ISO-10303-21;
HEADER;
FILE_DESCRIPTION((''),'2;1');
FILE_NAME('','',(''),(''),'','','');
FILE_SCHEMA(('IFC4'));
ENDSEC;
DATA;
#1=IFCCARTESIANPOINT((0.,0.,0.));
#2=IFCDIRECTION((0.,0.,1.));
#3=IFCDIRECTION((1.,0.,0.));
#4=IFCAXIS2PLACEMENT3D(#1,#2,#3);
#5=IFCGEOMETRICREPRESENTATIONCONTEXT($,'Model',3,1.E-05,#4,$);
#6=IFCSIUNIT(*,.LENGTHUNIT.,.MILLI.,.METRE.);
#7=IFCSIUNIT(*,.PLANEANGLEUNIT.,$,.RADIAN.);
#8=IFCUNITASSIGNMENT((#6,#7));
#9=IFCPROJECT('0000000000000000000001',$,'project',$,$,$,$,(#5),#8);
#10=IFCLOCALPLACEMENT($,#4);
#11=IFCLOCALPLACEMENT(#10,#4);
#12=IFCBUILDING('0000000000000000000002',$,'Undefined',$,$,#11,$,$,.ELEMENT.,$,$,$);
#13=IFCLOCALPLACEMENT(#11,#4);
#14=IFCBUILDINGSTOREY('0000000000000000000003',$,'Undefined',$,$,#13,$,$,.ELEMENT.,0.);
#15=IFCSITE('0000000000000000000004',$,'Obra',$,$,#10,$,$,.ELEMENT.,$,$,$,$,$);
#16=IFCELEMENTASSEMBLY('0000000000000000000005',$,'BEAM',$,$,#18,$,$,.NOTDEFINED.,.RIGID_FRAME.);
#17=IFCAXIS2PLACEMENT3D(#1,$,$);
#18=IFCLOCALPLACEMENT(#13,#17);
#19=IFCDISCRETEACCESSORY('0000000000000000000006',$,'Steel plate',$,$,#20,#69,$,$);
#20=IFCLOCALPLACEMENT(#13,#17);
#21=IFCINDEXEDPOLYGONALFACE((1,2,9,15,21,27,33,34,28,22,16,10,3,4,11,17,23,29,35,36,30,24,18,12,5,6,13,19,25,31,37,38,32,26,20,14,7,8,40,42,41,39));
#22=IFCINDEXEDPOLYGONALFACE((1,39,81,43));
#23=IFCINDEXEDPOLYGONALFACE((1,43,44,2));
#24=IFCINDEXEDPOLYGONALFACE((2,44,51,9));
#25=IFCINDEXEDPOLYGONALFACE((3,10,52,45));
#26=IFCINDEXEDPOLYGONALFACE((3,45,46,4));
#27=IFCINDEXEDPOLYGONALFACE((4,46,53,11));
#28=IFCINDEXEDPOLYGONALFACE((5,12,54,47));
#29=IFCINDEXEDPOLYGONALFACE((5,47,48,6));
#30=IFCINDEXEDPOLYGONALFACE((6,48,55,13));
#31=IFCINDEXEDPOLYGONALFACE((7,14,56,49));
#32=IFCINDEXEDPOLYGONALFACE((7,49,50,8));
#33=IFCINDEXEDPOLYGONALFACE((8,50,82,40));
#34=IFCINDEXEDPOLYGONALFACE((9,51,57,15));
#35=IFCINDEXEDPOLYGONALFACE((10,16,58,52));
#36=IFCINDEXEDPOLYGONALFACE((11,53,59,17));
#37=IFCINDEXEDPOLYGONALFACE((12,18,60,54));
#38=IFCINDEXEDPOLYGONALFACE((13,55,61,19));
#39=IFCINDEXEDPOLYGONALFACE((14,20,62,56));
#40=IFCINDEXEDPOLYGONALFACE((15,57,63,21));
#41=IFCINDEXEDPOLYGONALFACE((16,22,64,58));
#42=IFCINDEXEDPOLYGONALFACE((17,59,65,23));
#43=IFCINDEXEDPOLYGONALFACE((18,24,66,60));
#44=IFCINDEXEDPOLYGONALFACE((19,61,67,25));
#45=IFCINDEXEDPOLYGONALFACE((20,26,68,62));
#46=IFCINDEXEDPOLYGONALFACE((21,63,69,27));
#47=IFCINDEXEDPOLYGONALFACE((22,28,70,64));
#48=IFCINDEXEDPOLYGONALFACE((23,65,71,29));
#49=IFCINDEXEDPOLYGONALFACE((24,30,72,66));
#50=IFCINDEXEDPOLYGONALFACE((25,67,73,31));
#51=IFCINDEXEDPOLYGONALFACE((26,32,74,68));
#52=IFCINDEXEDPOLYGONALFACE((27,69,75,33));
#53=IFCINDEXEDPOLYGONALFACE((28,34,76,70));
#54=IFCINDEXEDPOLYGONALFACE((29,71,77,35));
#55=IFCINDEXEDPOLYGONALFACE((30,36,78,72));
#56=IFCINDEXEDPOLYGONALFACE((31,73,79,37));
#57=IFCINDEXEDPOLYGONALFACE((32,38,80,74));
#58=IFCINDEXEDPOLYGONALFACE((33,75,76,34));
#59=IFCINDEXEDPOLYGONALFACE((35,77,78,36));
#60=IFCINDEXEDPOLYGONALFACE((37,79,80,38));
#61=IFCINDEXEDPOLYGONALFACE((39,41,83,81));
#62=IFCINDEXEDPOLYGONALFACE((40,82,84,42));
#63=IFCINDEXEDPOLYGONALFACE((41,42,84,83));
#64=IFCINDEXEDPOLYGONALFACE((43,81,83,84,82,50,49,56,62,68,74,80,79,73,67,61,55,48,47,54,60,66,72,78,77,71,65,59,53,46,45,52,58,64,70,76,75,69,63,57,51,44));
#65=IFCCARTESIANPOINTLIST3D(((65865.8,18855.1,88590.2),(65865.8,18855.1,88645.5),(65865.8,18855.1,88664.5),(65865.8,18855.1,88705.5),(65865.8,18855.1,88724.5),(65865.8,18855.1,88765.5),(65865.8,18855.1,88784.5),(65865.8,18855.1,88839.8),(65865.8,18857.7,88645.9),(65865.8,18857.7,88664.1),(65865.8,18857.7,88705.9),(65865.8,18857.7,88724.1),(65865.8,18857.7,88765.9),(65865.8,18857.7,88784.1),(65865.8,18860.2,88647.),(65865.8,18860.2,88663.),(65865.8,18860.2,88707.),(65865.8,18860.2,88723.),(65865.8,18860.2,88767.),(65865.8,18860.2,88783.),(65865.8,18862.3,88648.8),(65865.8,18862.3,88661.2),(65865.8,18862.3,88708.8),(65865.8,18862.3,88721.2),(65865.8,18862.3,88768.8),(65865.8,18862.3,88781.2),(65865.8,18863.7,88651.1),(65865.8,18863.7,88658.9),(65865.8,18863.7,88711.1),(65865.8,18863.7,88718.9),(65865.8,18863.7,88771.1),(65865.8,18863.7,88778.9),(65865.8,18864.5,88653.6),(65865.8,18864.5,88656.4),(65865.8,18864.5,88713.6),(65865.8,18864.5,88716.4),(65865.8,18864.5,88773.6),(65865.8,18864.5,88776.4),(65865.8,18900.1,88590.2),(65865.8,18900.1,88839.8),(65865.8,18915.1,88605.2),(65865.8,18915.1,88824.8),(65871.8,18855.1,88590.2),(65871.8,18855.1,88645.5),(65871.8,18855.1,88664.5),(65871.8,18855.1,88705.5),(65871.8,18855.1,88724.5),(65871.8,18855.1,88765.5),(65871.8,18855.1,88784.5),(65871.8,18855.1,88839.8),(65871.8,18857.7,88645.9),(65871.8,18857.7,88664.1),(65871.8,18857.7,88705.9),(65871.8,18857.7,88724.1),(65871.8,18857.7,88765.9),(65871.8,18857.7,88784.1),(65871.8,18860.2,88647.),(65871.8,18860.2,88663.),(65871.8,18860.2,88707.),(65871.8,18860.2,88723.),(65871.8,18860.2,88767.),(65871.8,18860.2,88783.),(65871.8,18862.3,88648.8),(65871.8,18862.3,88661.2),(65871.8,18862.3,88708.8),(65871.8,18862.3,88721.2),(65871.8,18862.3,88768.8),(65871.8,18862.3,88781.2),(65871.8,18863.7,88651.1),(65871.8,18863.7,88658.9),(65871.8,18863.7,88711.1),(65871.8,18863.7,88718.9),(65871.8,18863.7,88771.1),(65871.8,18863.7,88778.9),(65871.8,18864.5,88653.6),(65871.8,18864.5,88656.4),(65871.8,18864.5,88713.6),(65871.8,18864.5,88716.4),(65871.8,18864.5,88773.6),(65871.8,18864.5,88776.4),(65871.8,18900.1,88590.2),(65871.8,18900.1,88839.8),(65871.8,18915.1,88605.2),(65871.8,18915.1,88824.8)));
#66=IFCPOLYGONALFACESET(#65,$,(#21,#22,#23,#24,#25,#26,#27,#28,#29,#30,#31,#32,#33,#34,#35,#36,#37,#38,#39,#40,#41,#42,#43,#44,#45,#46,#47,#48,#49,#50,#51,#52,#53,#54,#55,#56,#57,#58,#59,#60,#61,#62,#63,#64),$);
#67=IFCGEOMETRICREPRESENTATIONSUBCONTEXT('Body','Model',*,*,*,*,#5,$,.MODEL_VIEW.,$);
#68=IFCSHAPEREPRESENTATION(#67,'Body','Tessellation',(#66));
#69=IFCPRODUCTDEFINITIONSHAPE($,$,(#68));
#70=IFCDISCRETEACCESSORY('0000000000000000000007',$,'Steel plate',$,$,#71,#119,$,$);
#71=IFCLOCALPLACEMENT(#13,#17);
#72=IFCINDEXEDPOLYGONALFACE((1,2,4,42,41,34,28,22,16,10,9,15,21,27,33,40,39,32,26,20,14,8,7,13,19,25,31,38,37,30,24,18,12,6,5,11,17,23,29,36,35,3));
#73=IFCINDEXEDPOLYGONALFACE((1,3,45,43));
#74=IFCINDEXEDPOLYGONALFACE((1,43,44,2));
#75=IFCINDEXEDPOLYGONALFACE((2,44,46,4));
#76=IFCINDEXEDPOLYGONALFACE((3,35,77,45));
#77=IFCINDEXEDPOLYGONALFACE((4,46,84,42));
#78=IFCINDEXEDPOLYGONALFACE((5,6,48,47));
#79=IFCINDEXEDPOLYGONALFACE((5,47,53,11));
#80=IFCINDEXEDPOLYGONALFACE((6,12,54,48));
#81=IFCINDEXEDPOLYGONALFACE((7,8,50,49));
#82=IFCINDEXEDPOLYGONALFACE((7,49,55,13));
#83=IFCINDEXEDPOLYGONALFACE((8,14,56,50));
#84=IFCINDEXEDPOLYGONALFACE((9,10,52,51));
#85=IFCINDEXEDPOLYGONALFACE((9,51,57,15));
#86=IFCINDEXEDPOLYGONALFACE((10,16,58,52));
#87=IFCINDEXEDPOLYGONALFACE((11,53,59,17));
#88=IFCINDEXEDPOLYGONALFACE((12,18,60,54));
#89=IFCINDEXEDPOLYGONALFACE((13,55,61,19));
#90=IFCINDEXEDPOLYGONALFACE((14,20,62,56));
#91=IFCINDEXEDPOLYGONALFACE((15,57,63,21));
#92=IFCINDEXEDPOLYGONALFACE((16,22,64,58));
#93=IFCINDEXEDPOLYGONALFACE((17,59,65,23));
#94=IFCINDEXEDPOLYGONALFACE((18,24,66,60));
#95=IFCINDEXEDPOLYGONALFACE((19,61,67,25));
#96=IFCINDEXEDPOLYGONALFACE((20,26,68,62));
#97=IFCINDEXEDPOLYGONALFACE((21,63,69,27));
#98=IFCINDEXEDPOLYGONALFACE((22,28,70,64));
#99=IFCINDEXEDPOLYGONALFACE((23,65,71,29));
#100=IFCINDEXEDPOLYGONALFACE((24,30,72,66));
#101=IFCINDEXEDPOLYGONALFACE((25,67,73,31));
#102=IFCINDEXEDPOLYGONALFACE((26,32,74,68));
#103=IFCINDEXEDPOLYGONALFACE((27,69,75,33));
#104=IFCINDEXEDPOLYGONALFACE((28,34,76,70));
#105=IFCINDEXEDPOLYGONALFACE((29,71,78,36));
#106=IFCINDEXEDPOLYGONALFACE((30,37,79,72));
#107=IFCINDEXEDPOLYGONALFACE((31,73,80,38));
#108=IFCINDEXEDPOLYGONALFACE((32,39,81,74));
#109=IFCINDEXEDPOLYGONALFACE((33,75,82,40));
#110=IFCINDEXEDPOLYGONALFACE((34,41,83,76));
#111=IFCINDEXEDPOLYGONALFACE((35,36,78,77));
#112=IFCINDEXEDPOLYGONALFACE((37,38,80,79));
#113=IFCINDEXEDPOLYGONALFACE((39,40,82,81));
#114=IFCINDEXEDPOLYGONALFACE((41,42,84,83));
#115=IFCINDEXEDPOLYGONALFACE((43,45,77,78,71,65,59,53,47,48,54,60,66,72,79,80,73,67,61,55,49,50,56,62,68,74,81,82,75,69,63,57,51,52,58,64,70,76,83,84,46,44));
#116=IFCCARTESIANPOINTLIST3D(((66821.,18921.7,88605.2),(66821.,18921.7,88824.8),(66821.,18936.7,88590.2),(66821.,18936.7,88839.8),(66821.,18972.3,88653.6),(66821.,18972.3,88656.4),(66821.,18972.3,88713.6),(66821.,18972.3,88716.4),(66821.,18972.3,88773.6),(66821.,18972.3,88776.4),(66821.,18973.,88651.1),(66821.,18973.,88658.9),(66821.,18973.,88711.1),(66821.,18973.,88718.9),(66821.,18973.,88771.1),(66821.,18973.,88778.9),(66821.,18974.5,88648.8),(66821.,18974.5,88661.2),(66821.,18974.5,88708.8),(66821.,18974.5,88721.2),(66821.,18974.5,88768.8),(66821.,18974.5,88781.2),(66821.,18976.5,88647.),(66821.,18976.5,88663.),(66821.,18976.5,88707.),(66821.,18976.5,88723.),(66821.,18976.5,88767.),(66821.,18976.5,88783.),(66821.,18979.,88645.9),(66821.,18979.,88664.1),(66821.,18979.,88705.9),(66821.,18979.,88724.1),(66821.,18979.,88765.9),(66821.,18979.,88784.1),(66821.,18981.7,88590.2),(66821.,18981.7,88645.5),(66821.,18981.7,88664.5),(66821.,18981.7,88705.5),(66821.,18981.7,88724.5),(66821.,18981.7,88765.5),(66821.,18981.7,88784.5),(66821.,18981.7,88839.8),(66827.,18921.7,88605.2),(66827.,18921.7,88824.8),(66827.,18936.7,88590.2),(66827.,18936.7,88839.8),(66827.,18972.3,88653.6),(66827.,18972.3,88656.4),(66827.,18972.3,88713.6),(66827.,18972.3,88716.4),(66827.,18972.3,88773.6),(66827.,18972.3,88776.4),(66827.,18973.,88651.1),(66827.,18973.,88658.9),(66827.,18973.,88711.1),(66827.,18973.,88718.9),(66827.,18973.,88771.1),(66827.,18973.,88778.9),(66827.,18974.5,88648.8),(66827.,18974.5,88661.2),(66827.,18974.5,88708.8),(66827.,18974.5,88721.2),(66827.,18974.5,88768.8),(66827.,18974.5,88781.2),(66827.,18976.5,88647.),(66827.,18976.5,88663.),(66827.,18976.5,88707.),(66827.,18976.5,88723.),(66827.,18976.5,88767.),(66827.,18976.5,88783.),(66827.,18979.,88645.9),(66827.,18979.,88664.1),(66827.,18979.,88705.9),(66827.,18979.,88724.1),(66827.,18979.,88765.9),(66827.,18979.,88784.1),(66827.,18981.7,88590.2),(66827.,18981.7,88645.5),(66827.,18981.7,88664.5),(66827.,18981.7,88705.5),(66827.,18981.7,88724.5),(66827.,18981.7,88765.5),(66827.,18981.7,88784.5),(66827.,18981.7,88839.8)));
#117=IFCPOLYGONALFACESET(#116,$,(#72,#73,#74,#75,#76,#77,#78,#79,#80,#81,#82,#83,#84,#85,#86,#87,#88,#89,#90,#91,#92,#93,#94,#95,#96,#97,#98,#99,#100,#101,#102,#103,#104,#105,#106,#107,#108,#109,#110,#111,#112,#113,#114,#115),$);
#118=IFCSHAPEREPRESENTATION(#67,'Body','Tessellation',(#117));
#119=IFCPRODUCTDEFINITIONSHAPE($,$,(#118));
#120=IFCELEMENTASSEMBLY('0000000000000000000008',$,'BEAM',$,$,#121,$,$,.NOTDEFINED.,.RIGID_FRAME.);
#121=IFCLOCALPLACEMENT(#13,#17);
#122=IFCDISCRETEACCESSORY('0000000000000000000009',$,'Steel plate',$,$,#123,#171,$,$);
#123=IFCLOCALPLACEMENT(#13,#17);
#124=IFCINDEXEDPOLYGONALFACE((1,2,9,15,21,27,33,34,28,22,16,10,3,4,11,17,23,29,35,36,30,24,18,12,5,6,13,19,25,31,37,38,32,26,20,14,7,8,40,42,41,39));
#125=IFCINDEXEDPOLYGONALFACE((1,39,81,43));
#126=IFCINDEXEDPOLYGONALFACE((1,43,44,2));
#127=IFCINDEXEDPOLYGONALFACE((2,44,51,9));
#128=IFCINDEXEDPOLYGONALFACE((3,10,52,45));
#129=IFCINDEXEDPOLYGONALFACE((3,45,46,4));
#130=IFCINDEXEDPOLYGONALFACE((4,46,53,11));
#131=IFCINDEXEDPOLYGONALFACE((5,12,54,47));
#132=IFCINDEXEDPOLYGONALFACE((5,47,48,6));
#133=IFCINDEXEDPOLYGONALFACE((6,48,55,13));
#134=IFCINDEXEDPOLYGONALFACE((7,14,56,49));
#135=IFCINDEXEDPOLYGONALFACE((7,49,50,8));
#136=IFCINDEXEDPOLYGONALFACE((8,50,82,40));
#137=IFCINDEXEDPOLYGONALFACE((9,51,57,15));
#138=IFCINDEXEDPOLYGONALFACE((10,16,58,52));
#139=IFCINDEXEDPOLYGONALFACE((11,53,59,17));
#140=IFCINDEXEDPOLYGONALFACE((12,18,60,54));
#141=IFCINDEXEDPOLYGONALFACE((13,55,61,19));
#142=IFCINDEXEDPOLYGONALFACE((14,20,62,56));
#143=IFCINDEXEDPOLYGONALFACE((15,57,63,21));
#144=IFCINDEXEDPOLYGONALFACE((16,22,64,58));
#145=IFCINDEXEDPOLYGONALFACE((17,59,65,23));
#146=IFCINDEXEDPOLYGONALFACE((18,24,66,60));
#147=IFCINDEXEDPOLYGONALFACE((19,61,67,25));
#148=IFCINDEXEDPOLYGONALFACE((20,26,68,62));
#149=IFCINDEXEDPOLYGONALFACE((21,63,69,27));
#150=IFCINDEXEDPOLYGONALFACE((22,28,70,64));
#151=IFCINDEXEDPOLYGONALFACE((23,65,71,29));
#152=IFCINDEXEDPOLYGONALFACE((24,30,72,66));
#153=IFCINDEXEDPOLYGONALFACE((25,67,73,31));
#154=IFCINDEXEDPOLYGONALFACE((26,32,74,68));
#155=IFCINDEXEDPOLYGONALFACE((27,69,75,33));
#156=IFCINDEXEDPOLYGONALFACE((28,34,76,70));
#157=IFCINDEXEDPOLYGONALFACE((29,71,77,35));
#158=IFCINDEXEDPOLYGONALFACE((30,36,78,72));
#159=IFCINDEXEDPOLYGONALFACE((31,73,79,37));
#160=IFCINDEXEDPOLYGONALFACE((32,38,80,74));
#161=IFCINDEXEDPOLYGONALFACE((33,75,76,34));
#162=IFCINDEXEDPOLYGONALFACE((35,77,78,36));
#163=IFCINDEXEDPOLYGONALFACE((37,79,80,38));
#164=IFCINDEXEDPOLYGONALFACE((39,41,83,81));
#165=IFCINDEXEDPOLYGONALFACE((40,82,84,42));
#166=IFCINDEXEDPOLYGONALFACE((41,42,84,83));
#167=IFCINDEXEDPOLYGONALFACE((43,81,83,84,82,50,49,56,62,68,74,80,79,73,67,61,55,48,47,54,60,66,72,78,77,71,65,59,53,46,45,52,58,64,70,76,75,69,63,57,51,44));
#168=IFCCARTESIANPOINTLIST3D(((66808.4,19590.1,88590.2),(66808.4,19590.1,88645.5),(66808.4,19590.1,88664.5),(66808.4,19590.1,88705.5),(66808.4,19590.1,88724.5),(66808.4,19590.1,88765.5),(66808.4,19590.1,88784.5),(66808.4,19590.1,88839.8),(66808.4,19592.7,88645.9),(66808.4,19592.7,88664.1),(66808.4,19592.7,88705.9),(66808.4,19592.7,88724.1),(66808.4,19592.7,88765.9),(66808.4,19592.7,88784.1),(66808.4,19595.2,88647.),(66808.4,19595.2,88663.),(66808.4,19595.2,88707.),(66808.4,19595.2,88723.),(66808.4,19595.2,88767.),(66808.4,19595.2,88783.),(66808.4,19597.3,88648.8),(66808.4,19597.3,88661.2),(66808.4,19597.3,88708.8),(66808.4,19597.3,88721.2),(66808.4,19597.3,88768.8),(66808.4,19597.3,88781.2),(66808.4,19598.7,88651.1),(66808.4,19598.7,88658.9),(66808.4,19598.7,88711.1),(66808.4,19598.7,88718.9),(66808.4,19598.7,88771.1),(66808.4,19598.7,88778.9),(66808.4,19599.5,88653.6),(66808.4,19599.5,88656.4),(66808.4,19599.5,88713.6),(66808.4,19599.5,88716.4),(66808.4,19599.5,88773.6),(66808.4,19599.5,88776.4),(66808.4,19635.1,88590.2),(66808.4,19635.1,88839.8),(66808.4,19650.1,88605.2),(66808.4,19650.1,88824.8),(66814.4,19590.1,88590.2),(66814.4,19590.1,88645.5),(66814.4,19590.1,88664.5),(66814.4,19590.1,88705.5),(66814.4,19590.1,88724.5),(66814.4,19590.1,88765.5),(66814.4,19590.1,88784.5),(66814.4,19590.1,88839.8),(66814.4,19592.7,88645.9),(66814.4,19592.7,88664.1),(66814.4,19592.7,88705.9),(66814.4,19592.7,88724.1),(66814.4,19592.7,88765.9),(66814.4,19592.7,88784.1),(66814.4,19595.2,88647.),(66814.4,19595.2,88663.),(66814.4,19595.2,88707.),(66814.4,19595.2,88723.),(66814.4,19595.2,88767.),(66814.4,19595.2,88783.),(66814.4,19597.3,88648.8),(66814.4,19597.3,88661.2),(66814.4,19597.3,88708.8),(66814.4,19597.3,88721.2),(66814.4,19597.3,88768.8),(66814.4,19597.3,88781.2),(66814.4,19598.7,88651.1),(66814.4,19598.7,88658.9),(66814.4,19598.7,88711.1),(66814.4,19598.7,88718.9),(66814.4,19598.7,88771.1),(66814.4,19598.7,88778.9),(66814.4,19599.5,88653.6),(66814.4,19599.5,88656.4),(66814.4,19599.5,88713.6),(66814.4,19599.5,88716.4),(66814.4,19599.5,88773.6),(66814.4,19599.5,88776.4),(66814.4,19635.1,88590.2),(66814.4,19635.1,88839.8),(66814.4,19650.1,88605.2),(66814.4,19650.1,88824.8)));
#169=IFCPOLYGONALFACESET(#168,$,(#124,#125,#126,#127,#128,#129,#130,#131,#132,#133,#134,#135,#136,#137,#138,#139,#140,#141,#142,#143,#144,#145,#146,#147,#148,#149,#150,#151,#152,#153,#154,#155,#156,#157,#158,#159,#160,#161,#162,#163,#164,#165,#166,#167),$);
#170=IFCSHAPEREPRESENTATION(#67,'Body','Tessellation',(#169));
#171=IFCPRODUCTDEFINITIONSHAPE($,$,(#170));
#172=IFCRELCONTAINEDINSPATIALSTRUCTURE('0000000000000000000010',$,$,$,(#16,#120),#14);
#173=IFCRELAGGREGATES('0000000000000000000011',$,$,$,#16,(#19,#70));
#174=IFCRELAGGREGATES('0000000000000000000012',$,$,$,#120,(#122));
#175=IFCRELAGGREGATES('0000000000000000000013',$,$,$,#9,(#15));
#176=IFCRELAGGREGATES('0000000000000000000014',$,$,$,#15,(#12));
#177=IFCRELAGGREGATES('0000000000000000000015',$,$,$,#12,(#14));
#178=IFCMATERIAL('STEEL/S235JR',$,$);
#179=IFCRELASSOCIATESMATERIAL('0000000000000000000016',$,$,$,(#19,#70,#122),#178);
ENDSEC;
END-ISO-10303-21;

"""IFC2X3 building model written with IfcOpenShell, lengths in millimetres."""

from ifc_helpers import new_model, si_unit, frame, origin_with_axes, origin_2d_with_axis, place, context, subcontext, project, spatial, polyline, circle, outline, extrude, source, transform, mapped, material, element, aggregate, save


model = new_model("IFC2X3")

# Units and contexts
model_context = context("Model", 3, precision=1e-05, world=origin_with_axes())
body_context = subcontext(model_context, "Body", "Model", "MODEL_VIEW")
ifc_project = project(units=[si_unit("LENGTHUNIT", "METRE", prefix="MILLI"), si_unit("PLANEANGLEUNIT", "RADIAN")], contexts=[model_context])

# Site, building, storey
site_placement = place(None, origin_with_axes())
site = spatial("IfcSite", under=ifc_project, at=site_placement, Name="Obra", CompositionType="ELEMENT")
building_placement = place(site_placement, origin_with_axes())
building = spatial("IfcBuilding", under=site, at=building_placement, Name="Undefined", CompositionType="ELEMENT")
storey_placement = place(building_placement, origin_with_axes())
storey = spatial("IfcBuildingStorey", under=building, at=storey_placement, Name="Undefined", CompositionType="ELEMENT", Elevation=0.0)

# Shared definitions
ifc_material = material(Name="STEEL/S235JR")

# Element assemblies, discrete accessories, openings
assembly_1_placement = place(storey_placement, origin_with_axes())
assembly_1 = element("IfcElementAssembly", 1, at=assembly_1_placement, inside=storey, Name="BEAM", AssemblyPlace="NOTDEFINED", PredefinedType="RIGID_FRAME")
discrete_accessory_1_placement = place(assembly_1_placement, frame((65868.8, 18855.1, 88590.2), z_axis=(1.0, 0.000001, 0.0), x_axis=(-0.000002, 1.0, 0.0)))
discrete_accessory_1 = element("IfcDiscreteAccessory", 2, at=discrete_accessory_1_placement, material=ifc_material, Name="Steel plate", context=body_context, shape_type="SweptSolid", body=[
    extrude(outline(polyline([(0.0, 0.0), (45.0, 0.0), (60.0, 15.0), (60.0, 234.6), (45.0, 249.6), (0.0, 249.6), (0.0, 0.0)])), frame((0.0, 0.0, -3.0), z_axis=(0.0, 0.0, 1.0), x_axis=(1.0, 0.0, 0.0)), (0.0, 0.0, 1.0), 6.0),
])
shared_shape_1 = source(origin_with_axes(), body_context, "Body", "SweptSolid", [
    extrude(circle(Radius=9.5, at=origin_2d_with_axis()), frame((0.0, -9.4, 0.0), z_axis=(0.0, 1.0, 0.0), x_axis=(1.0, 0.0, 0.0)), (0.0, 0.0, 1.0), 6.2),
])
opening_1_placement = place(assembly_1_placement, frame((65875.1, 18905.1, 88850.0), z_axis=(0.000002, -1.0, 0.0), x_axis=(0.0, 0.0, -1.0)))
element("IfcOpeningElement", 3, at=opening_1_placement, cuts=discrete_accessory_1, ObjectType="Opening", context=body_context, shape_type="MappedRepresentation", body=[
    mapped(shared_shape_1, transform((75.0, 0.0, 50.0))),
    mapped(shared_shape_1, transform((135.0, 0.0, 50.0))),
    mapped(shared_shape_1, transform((195.0, 0.0, 50.0))),
])
discrete_accessory_2_placement = place(assembly_1_placement, frame((66824.0, 18981.7, 88590.2), z_axis=(-1.0, -0.000002, 0.0), x_axis=(0.000002, -1.0, 0.0)))
discrete_accessory_2 = element("IfcDiscreteAccessory", 4, at=discrete_accessory_2_placement, material=ifc_material, Name="Steel plate", context=body_context, shape_type="SweptSolid", body=[
    extrude(outline(polyline([(0.0, 0.0), (45.0, 0.0), (60.0, 15.0), (60.0, 234.6), (45.0, 249.6), (0.0, 249.6), (0.0, 0.0)])), frame((0.0, 0.0, -3.0), z_axis=(0.0, 0.0, 1.0), x_axis=(1.0, 0.0, 0.0)), (0.0, 0.0, 1.0), 6.0),
])
opening_2_placement = place(assembly_1_placement, frame((66817.7, 18931.7, 88850.0), z_axis=(-0.000002, 1.0, 0.0), x_axis=(0.0, 0.0, -1.0)))
element("IfcOpeningElement", 5, at=opening_2_placement, cuts=discrete_accessory_2, ObjectType="Opening", context=body_context, shape_type="MappedRepresentation", body=[
    mapped(shared_shape_1, transform((75.0, 0.0, 50.0))),
    mapped(shared_shape_1, transform((135.0, 0.0, 50.0))),
    mapped(shared_shape_1, transform((195.0, 0.0, 50.0))),
])
aggregate(assembly_1, [discrete_accessory_1, discrete_accessory_2])
assembly_2_placement = place(storey_placement, origin_with_axes())
assembly_2 = element("IfcElementAssembly", 6, at=assembly_2_placement, inside=storey, Name="BEAM", AssemblyPlace="NOTDEFINED", PredefinedType="RIGID_FRAME")
discrete_accessory_3_placement = place(assembly_2_placement, frame((66811.4, 19590.1, 88590.2), z_axis=(1.0, 0.000001, 0.0), x_axis=(-0.000002, 1.0, 0.0)))
discrete_accessory_3 = element("IfcDiscreteAccessory", 7, at=discrete_accessory_3_placement, material=ifc_material, Name="Steel plate", context=body_context, shape_type="SweptSolid", body=[
    extrude(outline(polyline([(0.0, 0.0), (45.0, 0.0), (60.0, 15.0), (60.0, 234.6), (45.0, 249.6), (0.0, 249.6), (0.0, 0.0)])), frame((0.0, 0.0, -3.0), z_axis=(0.0, 0.0, 1.0), x_axis=(1.0, 0.0, 0.0)), (0.0, 0.0, 1.0), 6.0),
])
opening_3_placement = place(assembly_2_placement, frame((66817.7, 19640.1, 88850.0), z_axis=(0.000002, -1.0, 0.0), x_axis=(0.0, 0.0, -1.0)))
element("IfcOpeningElement", 8, at=opening_3_placement, cuts=discrete_accessory_3, ObjectType="Opening", context=body_context, shape_type="MappedRepresentation", body=[
    mapped(shared_shape_1, transform((75.0, 0.0, 50.0))),
    mapped(shared_shape_1, transform((135.0, 0.0, 50.0))),
    mapped(shared_shape_1, transform((195.0, 0.0, 50.0))),
])
aggregate(assembly_2, [discrete_accessory_3])

save(model, "model.ifc")
